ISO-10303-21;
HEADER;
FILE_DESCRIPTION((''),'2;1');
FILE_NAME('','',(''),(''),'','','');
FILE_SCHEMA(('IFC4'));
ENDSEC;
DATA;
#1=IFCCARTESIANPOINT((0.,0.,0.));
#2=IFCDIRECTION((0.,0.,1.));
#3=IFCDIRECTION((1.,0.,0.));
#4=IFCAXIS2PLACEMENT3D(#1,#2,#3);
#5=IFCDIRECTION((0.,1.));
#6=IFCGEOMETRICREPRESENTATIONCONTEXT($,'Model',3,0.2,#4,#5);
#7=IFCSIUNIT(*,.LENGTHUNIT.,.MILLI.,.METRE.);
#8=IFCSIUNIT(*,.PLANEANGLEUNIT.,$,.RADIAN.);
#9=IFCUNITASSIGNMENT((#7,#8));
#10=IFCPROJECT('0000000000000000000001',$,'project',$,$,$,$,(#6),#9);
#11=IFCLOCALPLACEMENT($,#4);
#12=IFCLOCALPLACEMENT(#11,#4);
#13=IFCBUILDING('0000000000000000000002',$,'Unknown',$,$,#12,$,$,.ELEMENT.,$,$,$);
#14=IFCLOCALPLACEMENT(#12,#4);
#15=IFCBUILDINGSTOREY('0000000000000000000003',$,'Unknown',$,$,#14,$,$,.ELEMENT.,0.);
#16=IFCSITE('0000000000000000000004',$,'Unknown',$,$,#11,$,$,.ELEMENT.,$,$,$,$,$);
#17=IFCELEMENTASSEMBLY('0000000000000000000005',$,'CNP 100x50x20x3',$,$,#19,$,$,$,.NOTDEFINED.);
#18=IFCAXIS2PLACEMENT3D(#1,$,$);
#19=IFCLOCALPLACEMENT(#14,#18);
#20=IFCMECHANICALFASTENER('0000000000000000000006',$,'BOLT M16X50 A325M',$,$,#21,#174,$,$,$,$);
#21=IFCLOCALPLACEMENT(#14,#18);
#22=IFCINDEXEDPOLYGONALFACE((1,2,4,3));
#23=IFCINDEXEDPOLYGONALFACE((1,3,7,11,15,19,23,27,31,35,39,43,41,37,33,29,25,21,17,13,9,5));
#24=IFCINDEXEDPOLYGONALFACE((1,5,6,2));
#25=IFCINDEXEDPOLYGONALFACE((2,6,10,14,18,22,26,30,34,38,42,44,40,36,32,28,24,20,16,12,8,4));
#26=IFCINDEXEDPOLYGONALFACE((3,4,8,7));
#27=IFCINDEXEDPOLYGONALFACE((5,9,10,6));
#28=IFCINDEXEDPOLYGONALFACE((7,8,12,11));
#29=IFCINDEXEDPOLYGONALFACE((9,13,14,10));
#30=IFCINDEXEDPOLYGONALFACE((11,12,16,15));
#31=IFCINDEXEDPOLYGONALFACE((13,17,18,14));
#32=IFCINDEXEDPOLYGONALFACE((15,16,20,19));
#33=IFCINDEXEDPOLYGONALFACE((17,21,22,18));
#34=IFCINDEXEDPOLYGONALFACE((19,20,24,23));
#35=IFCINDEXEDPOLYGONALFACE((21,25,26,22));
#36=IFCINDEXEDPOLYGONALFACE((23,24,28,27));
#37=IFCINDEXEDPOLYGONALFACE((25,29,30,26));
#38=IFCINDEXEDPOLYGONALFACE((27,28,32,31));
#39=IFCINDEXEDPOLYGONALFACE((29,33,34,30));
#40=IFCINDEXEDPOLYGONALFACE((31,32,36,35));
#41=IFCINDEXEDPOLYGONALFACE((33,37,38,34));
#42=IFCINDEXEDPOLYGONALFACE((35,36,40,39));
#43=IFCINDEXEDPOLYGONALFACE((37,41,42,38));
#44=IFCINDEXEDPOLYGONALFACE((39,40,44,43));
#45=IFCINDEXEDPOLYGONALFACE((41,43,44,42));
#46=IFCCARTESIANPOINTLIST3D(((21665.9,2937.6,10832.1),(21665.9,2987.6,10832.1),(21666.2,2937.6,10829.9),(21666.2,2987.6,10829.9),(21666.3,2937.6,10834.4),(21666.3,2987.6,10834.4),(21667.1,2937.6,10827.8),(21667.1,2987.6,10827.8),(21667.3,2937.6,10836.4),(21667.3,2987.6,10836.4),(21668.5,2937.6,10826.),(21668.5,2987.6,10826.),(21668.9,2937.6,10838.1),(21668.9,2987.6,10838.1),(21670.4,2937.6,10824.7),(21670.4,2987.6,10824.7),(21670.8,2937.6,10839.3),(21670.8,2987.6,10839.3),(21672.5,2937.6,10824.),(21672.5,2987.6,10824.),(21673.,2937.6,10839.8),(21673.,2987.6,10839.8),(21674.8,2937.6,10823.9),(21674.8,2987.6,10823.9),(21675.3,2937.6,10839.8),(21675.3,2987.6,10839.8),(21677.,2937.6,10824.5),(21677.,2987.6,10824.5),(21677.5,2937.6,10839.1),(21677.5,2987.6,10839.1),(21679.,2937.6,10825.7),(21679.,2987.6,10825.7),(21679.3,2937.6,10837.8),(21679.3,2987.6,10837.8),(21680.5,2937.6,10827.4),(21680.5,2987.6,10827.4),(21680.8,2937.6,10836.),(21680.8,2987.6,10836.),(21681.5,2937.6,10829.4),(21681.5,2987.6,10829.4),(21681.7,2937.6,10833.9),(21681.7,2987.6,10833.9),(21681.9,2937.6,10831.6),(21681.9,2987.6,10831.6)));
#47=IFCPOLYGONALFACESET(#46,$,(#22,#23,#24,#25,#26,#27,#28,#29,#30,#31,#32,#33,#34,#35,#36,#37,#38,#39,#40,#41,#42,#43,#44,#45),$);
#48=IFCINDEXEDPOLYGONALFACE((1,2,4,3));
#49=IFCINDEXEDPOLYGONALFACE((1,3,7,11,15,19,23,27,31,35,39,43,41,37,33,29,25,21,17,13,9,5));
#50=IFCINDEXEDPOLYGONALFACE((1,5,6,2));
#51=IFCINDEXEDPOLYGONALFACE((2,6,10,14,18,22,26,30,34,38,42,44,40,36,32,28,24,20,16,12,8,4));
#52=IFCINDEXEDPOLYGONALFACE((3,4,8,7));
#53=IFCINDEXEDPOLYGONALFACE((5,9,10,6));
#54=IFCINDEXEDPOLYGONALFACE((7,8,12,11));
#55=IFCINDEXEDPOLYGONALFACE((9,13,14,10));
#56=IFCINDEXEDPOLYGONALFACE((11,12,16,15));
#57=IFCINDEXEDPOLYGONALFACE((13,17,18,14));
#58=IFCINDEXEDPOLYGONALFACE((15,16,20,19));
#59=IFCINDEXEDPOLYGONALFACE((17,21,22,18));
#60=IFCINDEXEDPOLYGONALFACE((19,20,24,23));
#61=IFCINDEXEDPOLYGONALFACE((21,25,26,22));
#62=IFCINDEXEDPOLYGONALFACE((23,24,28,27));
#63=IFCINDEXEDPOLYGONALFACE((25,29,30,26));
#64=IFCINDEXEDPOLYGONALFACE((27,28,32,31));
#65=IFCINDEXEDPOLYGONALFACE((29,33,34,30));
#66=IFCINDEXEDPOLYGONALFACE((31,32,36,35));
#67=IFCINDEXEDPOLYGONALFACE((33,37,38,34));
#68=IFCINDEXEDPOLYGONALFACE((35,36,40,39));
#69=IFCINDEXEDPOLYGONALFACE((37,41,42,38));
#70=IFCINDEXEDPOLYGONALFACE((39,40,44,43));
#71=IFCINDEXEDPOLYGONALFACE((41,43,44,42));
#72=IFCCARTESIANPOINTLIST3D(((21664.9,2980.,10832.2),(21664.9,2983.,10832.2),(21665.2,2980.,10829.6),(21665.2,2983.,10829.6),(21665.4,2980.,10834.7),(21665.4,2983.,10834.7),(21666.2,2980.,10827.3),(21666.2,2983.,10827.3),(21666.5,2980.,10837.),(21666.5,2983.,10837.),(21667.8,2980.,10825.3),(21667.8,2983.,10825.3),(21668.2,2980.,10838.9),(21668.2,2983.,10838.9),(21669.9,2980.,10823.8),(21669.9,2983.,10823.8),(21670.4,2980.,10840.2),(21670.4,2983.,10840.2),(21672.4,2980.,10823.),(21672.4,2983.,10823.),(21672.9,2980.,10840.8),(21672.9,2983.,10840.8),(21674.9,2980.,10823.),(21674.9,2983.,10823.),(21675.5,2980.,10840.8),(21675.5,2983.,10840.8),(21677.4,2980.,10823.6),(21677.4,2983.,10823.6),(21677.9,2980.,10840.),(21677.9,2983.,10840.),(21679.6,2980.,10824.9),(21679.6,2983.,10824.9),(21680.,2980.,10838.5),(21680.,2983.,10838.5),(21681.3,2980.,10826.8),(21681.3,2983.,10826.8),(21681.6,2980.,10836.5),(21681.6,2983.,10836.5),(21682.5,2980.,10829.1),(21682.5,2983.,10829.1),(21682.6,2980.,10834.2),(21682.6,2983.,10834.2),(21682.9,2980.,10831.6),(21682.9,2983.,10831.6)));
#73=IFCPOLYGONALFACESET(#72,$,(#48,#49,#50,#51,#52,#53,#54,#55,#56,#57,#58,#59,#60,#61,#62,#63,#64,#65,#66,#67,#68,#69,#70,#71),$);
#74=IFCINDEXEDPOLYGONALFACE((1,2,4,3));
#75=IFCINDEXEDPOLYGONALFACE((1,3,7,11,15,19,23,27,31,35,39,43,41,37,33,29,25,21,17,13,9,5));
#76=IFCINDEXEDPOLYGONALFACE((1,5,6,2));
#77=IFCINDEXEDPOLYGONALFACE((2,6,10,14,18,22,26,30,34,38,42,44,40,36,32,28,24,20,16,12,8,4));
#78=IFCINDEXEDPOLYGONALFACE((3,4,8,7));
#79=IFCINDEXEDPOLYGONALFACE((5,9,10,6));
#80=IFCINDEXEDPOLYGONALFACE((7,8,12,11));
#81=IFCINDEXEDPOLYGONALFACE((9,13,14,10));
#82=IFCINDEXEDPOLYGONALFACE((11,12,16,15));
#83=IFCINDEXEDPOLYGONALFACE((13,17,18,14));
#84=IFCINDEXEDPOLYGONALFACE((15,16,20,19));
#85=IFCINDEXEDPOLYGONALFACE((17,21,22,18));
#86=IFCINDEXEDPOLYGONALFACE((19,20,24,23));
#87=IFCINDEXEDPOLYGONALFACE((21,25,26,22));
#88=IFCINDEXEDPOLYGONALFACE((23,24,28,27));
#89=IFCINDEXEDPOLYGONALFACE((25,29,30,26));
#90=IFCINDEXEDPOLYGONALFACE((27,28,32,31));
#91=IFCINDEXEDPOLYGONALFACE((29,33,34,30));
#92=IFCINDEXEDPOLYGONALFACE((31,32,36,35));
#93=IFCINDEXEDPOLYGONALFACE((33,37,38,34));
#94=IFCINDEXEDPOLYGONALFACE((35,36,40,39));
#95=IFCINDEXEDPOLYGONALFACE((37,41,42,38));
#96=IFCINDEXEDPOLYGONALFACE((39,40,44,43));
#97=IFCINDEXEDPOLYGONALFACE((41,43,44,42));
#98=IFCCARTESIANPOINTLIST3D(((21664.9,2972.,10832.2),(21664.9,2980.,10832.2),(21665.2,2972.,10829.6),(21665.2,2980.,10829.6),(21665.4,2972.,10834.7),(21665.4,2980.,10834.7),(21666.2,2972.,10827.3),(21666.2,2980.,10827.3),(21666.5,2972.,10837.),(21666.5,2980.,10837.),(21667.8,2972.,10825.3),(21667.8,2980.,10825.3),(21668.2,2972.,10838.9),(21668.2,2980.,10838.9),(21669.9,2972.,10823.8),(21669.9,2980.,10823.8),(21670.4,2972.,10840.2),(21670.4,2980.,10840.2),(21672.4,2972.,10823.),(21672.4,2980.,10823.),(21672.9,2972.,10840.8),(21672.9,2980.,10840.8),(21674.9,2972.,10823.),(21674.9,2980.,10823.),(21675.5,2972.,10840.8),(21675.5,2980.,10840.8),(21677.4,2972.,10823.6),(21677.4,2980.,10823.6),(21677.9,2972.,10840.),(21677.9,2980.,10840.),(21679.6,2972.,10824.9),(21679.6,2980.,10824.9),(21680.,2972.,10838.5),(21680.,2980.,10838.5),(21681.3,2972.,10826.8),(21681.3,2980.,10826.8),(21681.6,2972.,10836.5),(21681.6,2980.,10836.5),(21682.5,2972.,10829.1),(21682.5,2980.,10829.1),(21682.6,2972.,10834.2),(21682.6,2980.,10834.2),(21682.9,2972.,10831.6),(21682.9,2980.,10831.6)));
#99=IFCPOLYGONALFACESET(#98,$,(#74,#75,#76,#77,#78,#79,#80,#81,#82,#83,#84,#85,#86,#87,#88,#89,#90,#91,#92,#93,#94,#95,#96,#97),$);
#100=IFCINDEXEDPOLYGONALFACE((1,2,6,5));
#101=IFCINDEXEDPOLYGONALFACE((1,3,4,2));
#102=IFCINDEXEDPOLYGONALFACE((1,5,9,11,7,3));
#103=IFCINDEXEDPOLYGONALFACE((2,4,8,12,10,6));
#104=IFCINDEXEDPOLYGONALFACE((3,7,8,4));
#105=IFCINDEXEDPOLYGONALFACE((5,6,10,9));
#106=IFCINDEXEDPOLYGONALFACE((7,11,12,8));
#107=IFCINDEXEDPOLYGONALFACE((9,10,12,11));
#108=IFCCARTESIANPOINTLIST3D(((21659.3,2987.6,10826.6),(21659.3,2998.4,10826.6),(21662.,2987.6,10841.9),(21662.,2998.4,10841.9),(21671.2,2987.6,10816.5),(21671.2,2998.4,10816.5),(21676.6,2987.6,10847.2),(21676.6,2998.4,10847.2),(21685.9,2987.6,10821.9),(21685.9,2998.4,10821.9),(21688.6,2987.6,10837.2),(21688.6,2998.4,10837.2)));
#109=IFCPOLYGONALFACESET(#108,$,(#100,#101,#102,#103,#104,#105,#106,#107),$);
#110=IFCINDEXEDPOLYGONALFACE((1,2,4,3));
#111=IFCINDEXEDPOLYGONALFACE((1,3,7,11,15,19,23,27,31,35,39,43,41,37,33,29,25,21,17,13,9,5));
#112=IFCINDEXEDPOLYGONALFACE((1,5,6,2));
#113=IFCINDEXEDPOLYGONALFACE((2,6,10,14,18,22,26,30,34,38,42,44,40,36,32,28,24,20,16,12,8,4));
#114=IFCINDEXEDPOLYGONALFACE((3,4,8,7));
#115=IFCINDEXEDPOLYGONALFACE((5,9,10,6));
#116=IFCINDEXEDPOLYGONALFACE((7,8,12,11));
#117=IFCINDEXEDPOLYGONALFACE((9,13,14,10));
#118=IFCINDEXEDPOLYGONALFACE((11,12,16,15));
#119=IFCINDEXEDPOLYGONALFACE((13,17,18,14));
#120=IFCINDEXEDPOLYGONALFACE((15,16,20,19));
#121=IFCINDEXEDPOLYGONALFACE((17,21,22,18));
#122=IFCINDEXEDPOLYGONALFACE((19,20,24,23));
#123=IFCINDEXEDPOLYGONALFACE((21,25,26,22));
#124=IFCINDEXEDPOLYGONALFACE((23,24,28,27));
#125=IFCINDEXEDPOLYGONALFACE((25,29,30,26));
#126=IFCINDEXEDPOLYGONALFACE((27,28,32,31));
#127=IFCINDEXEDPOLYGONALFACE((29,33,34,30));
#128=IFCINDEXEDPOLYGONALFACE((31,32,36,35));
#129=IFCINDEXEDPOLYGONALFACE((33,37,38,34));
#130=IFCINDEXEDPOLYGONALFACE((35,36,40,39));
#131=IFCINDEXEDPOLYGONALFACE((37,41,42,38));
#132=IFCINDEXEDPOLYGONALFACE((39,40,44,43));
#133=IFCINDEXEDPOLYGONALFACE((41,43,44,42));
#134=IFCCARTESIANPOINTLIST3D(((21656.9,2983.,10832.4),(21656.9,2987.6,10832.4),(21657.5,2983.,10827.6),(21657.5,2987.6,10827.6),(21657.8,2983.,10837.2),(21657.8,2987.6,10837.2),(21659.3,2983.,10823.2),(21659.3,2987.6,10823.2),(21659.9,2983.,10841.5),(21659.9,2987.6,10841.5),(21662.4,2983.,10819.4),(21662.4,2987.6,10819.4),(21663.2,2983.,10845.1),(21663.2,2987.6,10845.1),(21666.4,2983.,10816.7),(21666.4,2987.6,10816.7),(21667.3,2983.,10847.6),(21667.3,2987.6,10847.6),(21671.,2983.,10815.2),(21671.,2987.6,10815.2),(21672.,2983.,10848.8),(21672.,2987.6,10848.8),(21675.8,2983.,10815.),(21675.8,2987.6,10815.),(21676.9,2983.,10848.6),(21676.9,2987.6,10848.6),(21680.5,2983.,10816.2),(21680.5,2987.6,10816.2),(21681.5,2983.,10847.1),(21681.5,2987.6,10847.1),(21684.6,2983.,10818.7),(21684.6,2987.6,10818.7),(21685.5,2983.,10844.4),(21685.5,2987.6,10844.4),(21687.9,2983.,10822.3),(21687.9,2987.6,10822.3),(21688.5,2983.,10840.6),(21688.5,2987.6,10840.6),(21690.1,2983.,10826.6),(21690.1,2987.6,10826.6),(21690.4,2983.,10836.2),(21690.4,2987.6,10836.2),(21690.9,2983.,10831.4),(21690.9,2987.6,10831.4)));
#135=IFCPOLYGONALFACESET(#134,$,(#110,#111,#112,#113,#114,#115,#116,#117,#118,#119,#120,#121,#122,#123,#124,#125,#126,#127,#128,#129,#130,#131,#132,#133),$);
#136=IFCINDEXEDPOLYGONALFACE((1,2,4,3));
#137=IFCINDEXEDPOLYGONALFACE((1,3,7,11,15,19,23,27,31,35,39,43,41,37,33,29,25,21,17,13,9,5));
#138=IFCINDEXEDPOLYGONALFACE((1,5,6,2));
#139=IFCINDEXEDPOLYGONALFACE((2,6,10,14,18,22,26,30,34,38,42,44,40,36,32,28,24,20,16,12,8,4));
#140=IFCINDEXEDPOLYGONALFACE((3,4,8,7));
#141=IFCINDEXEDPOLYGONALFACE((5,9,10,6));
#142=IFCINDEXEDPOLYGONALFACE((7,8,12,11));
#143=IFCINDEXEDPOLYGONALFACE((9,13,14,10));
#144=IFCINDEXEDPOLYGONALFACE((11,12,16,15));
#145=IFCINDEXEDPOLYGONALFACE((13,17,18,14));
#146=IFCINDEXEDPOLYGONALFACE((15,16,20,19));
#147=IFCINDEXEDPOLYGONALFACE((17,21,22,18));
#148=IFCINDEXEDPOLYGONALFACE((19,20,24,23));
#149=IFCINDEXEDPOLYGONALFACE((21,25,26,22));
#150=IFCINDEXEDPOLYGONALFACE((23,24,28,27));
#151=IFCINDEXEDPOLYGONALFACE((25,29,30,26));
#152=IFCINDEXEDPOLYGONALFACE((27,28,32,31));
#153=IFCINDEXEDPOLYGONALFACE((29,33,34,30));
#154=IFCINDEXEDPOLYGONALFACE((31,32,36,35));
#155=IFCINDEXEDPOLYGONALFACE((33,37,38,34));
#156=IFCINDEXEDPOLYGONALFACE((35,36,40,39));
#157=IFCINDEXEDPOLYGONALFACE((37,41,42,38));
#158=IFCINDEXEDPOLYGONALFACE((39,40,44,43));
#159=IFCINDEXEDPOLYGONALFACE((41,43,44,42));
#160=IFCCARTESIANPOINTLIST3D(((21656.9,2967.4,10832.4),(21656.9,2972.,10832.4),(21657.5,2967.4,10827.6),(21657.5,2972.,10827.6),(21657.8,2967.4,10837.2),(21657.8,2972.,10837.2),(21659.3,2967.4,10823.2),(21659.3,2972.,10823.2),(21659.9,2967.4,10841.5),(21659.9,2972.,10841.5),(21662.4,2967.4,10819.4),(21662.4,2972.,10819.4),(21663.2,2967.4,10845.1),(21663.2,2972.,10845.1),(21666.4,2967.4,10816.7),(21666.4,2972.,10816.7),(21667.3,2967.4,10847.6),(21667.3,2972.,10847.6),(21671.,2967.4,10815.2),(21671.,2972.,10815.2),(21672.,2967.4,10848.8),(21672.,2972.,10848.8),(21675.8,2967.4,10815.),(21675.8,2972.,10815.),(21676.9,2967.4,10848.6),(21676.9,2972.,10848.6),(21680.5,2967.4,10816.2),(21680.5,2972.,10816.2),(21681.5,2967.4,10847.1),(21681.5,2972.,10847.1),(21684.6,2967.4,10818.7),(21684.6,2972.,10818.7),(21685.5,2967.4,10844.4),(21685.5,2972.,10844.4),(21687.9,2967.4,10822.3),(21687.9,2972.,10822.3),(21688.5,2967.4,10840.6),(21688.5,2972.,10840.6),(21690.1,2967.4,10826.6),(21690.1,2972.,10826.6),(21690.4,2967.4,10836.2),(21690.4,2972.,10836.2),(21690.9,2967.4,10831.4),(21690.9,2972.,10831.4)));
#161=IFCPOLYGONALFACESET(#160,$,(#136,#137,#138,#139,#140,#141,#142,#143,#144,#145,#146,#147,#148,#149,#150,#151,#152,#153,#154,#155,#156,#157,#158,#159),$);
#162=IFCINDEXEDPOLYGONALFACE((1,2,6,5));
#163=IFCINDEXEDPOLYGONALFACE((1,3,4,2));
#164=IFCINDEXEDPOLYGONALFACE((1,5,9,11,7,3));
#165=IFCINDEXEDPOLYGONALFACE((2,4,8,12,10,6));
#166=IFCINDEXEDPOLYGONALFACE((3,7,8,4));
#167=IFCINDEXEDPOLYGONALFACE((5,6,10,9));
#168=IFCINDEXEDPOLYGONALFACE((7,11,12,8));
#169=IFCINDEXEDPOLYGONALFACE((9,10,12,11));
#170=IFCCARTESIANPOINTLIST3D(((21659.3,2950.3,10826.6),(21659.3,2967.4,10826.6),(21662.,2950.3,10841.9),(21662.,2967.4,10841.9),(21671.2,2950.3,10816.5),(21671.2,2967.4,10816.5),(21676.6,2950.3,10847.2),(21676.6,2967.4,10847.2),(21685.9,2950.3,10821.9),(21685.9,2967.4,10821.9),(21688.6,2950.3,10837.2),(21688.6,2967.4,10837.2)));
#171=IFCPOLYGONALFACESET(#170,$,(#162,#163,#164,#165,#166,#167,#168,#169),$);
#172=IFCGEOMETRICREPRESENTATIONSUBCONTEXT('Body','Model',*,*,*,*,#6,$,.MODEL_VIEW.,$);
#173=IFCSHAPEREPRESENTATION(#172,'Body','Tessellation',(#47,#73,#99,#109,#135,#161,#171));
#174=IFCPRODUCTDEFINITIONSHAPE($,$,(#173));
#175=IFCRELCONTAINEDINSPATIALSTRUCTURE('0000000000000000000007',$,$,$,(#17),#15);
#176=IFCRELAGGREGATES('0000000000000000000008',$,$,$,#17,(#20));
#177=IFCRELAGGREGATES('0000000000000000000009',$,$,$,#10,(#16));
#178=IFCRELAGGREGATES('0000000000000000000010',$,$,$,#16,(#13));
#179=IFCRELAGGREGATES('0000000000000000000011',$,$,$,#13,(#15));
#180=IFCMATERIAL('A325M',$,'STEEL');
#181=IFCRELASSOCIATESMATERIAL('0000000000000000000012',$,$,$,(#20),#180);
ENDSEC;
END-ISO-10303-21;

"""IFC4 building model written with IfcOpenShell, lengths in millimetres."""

from ifc_helpers import new_model, si_unit, direction, frame, origin_with_axes, place, context, subcontext, project, spatial, line, arc, indexed_curve, outline, extrude, source, transform, mapped, material, element, aggregate, save


model = new_model("IFC4")

# Units and contexts
model_context = context("Model", 3, precision=0.2, world=origin_with_axes(), true_north=direction((0.0, 1.0)))
body_context = subcontext(model_context, "Body", "Model", "MODEL_VIEW")
ifc_project = project(units=[si_unit("LENGTHUNIT", "METRE", prefix="MILLI"), si_unit("PLANEANGLEUNIT", "RADIAN")], contexts=[model_context])

# Site, building, storey
site_placement = place(None, origin_with_axes())
site = spatial("IfcSite", under=ifc_project, at=site_placement, Name="Unknown", CompositionType="ELEMENT")
building_placement = place(site_placement, origin_with_axes())
building = spatial("IfcBuilding", under=site, at=building_placement, Name="Unknown", CompositionType="ELEMENT")
storey_placement = place(building_placement, origin_with_axes())
storey = spatial("IfcBuildingStorey", under=building, at=storey_placement, Name="Unknown", CompositionType="ELEMENT", Elevation=0.0)

# Shared definitions
ifc_material_1 = material(Name="A325M", Category="STEEL")
shared_shape = source(origin_with_axes(), body_context, "Body", "SweptSolid", [
    extrude(outline(indexed_curve([(8.0, 0.0), (0.0, 8.0), (-8.0, 0.0), (0.0, -8.0)], segments=[arc(1, 2, 3), arc(3, 4, 1)])), frame((0.0, 0.0, 15.6), z_axis=(0.0, 0.0, -1.0), x_axis=(0.0, 1.0, 0.0)), (0.0, 0.0, 1.0), 50.0),
    extrude(outline(indexed_curve([(9.0, 0.0), (0.0, 9.0), (-9.0, 0.0), (0.0, -9.0)], segments=[arc(1, 2, 3), arc(3, 4, 1)])), frame((0.0, 0.0, 11.0), z_axis=(0.0, 0.0, -1.0), x_axis=(0.0, 1.0, 0.0)), (0.0, 0.0, 1.0), 3.0),
    extrude(outline(indexed_curve([(9.0, 0.0), (0.0, 9.0), (-9.0, 0.0), (0.0, -9.0)], segments=[arc(1, 2, 3), arc(3, 4, 1)])), frame((0.0, 0.0, 8.0), z_axis=(0.0, 0.0, -1.0), x_axis=(0.0, 1.0, 0.0)), (0.0, 0.0, 1.0), 8.0),
    extrude(outline(indexed_curve([(15.6, 0.0), (7.8, 13.5), (-7.8, 13.5), (-15.6, 0.0), (-7.8, -13.5), (7.8, -13.5)], segments=[line(1, 2, 3, 4, 5, 6, 1)])), frame((0.0, 0.0, 26.4), z_axis=(0.0, 0.0, -1.0), x_axis=(0.0, 1.0, 0.0)), (0.0, 0.0, 1.0), 10.8),
    extrude(outline(indexed_curve([(17.0, 0.0), (0.0, 17.0), (-17.0, 0.0), (0.0, -17.0)], segments=[arc(1, 2, 3), arc(3, 4, 1)])), frame((0.0, 0.0, 15.6), z_axis=(0.0, 0.0, -1.0), x_axis=(0.0, 1.0, 0.0)), (0.0, 0.0, 1.0), 4.6),
    extrude(outline(indexed_curve([(17.0, 0.0), (0.0, 17.0), (-17.0, 0.0), (0.0, -17.0)], segments=[arc(1, 2, 3), arc(3, 4, 1)])), frame((0.0, 0.0, 0.0), z_axis=(0.0, 0.0, -1.0), x_axis=(0.0, 1.0, 0.0)), (0.0, 0.0, 1.0), 4.6),
    extrude(outline(indexed_curve([(15.6, 0.0), (7.8, 13.5), (-7.8, 13.5), (-15.6, 0.0), (-7.8, -13.5), (7.8, -13.5)], segments=[line(1, 2, 3, 4, 5, 6, 1)])), frame((0.0, 0.0, -4.6), z_axis=(0.0, 0.0, -1.0), x_axis=(0.0, 1.0, 0.0)), (0.0, 0.0, 1.0), 17.1),
])

# Element assembly, mechanical fastener
assembly_1_placement = place(storey_placement, frame((25552.5, 3005.0, 10153.1), z_axis=(0.173648, 0.0, 0.984808), x_axis=(-0.984808, 0.0, 0.173648)))
assembly_1 = element("IfcElementAssembly", 1, at=assembly_1_placement, inside=storey, Name="CNP 100x50x20x3", PredefinedType="NOTDEFINED")
mechanical_fastener_1_placement = place(assembly_1_placement, frame((3937.5, 33.0, -5.0), z_axis=(0.0, -1.0, 0.0), x_axis=(-1.0, 0.0, 0.0)))
mechanical_fastener_1 = element("IfcMechanicalFastener", 2, at=mechanical_fastener_1_placement, material=ifc_material_1, Name="BOLT M16X50 A325M", context=body_context, shape_type="MappedRepresentation", body=[
    mapped(shared_shape, transform((0.0, 0.0, 0.0))),
])
aggregate(assembly_1, [mechanical_fastener_1])

save(model, "model.ifc")
